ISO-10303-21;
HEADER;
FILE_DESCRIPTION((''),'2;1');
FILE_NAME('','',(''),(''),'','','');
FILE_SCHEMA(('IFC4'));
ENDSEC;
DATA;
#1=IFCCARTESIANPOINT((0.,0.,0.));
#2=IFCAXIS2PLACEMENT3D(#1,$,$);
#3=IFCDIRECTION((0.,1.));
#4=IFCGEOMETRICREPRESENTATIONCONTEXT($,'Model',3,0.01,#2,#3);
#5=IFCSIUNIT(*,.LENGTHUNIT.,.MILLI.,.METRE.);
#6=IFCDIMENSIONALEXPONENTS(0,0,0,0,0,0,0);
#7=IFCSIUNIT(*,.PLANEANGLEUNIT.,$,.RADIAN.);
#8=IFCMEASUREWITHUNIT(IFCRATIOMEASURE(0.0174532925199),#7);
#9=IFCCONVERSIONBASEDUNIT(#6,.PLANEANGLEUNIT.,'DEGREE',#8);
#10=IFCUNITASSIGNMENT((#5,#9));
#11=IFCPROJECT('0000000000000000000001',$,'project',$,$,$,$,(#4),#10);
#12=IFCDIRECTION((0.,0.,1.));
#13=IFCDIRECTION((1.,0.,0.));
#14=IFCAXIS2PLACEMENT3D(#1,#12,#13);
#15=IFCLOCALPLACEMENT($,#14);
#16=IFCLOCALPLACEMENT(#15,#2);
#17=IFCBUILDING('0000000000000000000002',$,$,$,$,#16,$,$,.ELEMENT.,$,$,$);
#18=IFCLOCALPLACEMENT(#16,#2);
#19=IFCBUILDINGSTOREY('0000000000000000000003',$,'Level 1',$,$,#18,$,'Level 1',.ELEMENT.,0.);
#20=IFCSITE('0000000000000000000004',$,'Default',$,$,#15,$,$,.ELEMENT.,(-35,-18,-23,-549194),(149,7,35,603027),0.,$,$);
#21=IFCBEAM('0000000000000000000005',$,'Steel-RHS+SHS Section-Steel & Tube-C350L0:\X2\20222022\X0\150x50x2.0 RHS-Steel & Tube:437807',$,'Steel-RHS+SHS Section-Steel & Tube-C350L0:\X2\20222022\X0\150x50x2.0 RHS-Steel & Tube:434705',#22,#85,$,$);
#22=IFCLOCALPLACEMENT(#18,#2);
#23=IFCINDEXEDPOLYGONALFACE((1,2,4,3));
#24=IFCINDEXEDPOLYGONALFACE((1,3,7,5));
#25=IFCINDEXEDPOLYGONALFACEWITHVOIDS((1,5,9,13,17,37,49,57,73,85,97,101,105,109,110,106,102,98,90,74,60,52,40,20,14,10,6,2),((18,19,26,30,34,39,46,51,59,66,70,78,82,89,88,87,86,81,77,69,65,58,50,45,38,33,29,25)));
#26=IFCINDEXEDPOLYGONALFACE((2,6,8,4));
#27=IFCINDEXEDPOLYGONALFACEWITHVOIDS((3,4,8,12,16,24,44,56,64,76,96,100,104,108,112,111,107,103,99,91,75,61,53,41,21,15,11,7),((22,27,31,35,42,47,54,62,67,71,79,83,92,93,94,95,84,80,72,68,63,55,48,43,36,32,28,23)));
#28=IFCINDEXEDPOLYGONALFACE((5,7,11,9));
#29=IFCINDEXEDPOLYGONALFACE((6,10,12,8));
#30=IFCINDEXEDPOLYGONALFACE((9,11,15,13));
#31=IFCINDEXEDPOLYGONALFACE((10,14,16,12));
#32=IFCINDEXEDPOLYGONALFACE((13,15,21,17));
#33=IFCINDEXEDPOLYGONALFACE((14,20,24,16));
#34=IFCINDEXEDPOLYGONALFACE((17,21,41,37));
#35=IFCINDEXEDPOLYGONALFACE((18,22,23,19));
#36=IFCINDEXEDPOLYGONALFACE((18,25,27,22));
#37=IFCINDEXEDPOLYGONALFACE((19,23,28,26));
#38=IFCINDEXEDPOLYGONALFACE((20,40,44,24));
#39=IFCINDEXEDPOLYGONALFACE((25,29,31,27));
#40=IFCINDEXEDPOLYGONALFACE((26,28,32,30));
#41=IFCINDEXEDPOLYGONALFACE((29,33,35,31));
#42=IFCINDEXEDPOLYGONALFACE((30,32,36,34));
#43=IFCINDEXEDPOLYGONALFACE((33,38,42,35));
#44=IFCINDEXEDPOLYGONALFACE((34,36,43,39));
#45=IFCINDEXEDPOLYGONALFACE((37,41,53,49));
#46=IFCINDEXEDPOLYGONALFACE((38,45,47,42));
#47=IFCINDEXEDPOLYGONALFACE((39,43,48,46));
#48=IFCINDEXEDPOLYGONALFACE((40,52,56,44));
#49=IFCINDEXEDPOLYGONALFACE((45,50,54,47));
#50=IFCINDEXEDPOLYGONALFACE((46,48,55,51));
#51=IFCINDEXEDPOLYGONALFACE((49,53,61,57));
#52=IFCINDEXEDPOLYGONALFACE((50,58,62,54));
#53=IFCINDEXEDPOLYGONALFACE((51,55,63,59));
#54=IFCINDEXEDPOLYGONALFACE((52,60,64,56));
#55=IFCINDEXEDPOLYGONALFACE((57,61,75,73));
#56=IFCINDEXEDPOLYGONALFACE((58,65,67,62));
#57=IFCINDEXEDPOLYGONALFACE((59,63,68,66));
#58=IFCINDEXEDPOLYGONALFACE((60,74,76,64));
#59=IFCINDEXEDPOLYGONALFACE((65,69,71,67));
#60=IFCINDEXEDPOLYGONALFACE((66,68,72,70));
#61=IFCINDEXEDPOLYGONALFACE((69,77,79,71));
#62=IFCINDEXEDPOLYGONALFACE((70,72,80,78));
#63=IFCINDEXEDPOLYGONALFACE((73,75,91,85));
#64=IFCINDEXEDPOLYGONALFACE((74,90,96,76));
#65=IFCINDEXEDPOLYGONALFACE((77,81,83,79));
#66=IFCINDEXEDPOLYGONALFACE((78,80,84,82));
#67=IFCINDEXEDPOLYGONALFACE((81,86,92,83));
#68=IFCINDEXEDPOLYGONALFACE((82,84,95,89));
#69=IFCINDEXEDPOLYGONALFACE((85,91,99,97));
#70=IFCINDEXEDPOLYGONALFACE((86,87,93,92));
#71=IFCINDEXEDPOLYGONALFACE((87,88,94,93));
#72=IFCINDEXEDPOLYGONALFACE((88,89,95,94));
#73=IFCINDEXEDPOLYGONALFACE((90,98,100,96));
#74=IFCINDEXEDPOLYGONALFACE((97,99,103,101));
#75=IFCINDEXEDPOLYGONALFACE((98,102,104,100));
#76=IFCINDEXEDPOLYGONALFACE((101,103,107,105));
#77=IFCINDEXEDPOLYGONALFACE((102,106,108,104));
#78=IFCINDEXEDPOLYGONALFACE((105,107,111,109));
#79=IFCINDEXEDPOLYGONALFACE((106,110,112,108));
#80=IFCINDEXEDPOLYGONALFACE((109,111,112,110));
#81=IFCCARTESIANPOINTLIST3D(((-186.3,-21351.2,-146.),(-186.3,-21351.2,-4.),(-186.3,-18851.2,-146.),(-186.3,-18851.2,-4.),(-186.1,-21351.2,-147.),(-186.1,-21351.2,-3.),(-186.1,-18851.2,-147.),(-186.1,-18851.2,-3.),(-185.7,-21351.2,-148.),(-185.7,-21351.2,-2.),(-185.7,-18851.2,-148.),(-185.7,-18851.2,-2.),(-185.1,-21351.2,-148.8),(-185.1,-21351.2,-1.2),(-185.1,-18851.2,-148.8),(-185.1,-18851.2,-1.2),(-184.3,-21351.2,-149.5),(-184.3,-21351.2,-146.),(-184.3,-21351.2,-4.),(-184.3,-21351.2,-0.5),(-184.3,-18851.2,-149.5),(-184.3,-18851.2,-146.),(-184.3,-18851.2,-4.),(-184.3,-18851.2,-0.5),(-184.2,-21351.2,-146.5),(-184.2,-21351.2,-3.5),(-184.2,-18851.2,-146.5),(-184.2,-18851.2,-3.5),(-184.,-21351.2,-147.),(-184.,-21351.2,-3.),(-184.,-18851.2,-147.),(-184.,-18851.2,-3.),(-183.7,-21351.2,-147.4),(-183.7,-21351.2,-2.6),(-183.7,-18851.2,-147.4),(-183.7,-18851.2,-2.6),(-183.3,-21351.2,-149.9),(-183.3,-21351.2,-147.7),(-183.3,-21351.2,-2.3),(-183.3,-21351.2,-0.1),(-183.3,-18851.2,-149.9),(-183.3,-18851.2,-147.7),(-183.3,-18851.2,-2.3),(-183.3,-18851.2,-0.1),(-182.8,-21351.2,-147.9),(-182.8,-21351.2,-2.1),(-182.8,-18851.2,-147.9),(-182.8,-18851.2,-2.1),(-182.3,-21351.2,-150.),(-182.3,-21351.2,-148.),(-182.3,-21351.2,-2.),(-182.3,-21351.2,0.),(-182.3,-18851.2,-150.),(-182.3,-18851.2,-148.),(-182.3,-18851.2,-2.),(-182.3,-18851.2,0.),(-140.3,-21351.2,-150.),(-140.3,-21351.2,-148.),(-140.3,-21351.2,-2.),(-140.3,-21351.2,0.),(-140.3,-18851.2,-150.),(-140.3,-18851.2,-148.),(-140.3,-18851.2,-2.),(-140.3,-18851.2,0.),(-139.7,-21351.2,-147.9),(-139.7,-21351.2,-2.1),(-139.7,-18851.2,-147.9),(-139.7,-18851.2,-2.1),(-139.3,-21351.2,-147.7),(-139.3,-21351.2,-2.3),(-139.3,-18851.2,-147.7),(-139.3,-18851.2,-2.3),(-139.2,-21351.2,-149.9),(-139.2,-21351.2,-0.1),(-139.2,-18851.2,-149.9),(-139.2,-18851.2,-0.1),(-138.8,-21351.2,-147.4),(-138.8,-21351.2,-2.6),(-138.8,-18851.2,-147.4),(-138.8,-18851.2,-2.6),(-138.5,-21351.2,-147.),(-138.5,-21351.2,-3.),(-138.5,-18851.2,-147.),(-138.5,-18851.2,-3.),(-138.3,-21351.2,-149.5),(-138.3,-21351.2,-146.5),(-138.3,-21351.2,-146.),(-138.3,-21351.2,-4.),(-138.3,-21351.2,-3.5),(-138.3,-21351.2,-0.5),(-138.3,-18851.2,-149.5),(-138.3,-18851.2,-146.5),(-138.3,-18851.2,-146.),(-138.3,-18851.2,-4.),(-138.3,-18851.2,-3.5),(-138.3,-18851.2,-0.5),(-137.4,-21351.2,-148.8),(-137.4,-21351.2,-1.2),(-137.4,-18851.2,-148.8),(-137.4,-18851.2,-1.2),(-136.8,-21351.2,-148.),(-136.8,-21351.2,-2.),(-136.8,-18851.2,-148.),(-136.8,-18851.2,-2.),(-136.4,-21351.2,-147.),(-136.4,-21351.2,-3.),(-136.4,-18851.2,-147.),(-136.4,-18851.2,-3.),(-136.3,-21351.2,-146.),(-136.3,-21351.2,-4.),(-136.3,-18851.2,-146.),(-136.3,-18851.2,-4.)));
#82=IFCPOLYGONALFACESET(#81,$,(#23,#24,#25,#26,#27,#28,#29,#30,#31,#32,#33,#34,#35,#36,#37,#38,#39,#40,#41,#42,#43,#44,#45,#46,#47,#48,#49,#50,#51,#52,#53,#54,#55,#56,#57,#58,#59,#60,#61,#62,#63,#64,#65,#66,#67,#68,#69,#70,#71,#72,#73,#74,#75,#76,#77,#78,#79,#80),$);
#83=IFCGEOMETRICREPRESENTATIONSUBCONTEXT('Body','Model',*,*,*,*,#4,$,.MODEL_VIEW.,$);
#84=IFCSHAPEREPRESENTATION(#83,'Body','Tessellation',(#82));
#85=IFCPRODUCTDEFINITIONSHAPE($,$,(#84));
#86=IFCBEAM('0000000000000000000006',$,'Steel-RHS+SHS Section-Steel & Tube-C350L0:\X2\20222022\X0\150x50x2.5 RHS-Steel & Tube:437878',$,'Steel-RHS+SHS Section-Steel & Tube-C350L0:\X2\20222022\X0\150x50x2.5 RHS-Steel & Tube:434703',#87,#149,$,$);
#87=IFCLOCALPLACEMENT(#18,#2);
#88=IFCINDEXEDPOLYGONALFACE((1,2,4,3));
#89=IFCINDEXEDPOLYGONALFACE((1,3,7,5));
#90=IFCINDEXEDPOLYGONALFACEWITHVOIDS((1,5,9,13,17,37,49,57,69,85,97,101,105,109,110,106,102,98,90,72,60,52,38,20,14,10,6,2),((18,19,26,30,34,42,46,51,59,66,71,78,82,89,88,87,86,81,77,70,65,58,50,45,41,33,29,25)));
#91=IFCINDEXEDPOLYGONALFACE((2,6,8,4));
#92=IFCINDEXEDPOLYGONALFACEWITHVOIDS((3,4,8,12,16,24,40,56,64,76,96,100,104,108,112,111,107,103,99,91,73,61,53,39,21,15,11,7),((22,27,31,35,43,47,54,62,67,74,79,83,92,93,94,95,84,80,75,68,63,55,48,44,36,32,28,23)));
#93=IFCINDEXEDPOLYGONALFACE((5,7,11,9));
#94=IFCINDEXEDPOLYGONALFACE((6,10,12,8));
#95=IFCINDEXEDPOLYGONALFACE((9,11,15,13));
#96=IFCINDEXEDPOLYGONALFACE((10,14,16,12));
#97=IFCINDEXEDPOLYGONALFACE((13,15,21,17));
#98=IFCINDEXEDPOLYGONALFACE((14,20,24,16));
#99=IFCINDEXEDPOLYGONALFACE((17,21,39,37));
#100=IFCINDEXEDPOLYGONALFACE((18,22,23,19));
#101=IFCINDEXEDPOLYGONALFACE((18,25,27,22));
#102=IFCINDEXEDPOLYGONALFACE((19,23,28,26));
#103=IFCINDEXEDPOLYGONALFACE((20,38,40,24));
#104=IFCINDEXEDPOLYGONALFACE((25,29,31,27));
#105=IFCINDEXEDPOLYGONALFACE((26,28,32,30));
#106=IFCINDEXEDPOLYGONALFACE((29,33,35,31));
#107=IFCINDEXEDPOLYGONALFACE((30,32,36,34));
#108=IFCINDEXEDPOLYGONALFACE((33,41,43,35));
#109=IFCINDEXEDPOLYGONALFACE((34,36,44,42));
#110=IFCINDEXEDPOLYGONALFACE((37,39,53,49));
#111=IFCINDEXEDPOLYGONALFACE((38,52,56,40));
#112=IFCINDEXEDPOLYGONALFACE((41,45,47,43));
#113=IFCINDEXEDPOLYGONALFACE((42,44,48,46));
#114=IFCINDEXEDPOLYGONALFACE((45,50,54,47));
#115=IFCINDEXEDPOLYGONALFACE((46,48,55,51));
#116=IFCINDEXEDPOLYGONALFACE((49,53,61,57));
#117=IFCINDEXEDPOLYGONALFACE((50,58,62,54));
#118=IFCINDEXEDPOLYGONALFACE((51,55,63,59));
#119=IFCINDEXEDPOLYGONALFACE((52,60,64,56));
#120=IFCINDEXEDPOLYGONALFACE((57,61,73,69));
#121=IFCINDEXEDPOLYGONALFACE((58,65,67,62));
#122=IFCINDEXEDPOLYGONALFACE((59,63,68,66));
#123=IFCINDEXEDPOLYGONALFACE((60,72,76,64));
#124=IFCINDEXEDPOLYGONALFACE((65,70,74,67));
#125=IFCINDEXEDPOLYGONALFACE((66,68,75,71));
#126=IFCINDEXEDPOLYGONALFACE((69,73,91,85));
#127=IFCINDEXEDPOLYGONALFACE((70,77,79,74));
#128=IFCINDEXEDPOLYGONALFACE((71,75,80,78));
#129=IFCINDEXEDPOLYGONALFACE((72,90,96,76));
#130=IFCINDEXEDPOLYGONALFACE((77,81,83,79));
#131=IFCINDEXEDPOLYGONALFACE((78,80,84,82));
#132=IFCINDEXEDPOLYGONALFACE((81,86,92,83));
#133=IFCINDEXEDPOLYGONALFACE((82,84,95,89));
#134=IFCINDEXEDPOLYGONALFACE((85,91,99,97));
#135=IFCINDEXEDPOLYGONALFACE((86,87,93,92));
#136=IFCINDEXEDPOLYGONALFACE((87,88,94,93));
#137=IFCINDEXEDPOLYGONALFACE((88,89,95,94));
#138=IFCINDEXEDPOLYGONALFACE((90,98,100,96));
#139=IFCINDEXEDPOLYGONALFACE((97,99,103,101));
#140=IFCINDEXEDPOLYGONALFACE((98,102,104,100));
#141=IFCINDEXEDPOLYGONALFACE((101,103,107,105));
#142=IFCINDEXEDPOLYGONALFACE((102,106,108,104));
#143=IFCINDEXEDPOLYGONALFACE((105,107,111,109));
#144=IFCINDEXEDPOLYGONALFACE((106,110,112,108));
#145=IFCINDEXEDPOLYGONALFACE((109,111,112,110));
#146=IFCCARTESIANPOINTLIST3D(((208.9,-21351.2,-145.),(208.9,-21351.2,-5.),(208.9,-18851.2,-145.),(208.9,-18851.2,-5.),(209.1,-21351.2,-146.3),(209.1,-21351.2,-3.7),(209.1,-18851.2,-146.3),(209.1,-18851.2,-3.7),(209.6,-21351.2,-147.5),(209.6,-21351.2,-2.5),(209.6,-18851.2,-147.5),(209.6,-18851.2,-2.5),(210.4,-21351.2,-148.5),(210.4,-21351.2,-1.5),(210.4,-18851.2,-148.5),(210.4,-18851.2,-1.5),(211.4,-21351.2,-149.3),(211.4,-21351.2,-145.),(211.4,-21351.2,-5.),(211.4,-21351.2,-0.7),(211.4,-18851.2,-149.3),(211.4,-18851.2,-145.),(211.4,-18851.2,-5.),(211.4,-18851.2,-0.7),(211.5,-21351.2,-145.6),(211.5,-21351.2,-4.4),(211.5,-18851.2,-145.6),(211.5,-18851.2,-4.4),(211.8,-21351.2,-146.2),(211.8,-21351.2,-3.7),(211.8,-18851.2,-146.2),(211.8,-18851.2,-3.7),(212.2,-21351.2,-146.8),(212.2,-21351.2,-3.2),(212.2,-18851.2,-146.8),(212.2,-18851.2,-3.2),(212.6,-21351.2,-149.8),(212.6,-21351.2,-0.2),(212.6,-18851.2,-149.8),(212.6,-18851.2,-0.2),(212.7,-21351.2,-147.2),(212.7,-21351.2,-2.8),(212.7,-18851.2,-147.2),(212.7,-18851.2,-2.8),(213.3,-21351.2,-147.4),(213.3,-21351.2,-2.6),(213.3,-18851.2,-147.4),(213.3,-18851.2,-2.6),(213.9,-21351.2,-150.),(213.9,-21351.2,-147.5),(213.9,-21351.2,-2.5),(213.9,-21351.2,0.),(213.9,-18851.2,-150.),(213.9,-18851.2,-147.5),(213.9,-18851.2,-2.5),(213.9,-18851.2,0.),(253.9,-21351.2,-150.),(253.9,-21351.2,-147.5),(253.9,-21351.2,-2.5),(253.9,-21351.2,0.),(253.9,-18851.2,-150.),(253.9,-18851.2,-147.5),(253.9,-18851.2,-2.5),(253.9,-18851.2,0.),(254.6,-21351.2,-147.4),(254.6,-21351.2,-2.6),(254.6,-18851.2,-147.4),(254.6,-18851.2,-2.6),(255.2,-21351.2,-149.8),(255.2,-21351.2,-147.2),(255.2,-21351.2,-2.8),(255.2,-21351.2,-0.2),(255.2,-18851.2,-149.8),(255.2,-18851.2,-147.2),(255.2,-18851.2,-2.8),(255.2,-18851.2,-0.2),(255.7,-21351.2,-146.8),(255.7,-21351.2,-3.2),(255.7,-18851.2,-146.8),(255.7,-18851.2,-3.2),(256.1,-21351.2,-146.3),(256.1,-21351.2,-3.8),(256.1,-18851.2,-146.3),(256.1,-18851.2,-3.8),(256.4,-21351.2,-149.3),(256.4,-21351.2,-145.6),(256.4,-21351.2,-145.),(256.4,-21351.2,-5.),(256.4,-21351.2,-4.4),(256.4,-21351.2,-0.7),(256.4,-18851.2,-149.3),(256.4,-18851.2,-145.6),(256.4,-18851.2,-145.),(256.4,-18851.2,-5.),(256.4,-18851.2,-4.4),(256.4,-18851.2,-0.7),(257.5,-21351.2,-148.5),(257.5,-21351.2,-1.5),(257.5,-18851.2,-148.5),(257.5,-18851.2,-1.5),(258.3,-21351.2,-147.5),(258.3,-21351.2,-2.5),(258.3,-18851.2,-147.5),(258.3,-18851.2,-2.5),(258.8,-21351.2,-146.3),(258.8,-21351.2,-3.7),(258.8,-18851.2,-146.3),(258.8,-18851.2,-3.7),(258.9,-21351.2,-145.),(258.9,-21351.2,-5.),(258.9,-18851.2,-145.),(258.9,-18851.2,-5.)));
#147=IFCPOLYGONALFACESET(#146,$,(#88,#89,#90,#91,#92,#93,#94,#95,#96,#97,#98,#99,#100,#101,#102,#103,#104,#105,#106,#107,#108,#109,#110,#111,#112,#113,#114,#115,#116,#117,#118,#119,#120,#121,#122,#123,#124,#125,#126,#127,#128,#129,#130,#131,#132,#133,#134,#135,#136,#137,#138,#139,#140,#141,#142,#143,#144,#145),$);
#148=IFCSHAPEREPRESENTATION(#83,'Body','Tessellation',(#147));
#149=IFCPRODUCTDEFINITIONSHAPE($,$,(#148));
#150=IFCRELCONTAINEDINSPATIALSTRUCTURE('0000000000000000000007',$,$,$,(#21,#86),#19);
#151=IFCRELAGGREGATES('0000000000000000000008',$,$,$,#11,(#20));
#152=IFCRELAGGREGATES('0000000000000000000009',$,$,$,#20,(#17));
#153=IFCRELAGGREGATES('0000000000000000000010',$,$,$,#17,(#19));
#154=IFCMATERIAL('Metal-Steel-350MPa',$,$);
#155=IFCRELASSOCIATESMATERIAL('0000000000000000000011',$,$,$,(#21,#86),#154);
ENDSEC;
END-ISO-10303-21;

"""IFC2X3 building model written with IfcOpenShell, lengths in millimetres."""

from ifc_helpers import new_model, entity, si_unit, converted_unit, direction, frame, frame_2d, origin, origin_with_axes, place, context, subcontext, project, spatial, polyline, circle_curve, parameter, trimmed, segment, composite_curve, outline, extrude, material, element, save


model = new_model("IFC2X3")

# Units and contexts
model_context = context("Model", 3, precision=0.01, world=origin(), true_north=direction((0.0, 1.0)))
body_context = subcontext(model_context, "Body", "Model", "MODEL_VIEW")
ifc_project = project(units=[si_unit("LENGTHUNIT", "METRE", prefix="MILLI"), converted_unit("PLANEANGLEUNIT", "DEGREE", entity("IfcRatioMeasure", 0.0174532925199), si_unit("PLANEANGLEUNIT", "RADIAN"), dimensions=[0, 0, 0, 0, 0, 0, 0])], contexts=[model_context])

# Site, building, storey
site_placement = place(None, origin_with_axes())
site = spatial("IfcSite", under=ifc_project, at=site_placement, Name="Default", CompositionType="ELEMENT", RefLatitude=(-35, -18, -23, -549194), RefLongitude=(149, 7, 35, 603027), RefElevation=0.0)
building_placement = place(site_placement, origin())
building = spatial("IfcBuilding", under=site, at=building_placement, CompositionType="ELEMENT")
storey_placement = place(building_placement, origin())
storey = spatial("IfcBuildingStorey", under=building, at=storey_placement, Name="Level 1", LongName="Level 1", CompositionType="ELEMENT", Elevation=0.0)

# Beams
ifc_material = material(Name="Metal-Steel-350MPa")
beam_1_placement = place(storey_placement, frame((-161.3, -18851.2, 0.0), z_axis=(0.0, 0.0, 1.0), x_axis=(0.0, -1.0, 0.0)))
element("IfcBeam", 1, at=beam_1_placement, inside=storey, material=ifc_material, Name="Steel-RHS+SHS Section-Steel & Tube-C350L0:••150x50x2.0 RHS-Steel & Tube:437807", ObjectType="Steel-RHS+SHS Section-Steel & Tube-C350L0:••150x50x2.0 RHS-Steel & Tube:434705", context=body_context, shape_type="SweptSolid", body=[
    extrude(outline(composite_curve([segment(trimmed(circle_curve(frame_2d((-21.0, -71.0), x_axis=(1.0, 0.0)), 4.0), [parameter(180.0)], [parameter(270.0)], True, "PARAMETER"), True, "CONTINUOUS"), segment(polyline([(-21.0, -75.0), (21.0, -75.0)]), True, "CONTINUOUS"), segment(trimmed(circle_curve(frame_2d((21.0, -71.0), x_axis=(1.0, 0.0)), 4.0), [parameter(270.0)], [parameter(0.0)], True, "PARAMETER"), True, "CONTINUOUS"), segment(polyline([(25.0, -71.0), (25.0, 71.0)]), True, "CONTINUOUS"), segment(trimmed(circle_curve(frame_2d((21.0, 71.0), x_axis=(1.0, 0.0)), 4.0), [parameter(0.0)], [parameter(90.0)], True, "PARAMETER"), True, "CONTINUOUS"), segment(polyline([(21.0, 75.0), (-21.0, 75.0)]), True, "CONTINUOUS"), segment(trimmed(circle_curve(frame_2d((-21.0, 71.0), x_axis=(1.0, 0.0)), 4.0), [parameter(90.0)], [parameter(180.0)], True, "PARAMETER"), True, "CONTINUOUS"), segment(polyline([(-25.0, 71.0), (-25.0, -71.0)]), True, "CONTINUOUS")], self_intersect=False), holes=[composite_curve([segment(polyline([(21.0, -73.0), (-21.0, -73.0)]), True, "CONTINUOUS"), segment(trimmed(circle_curve(frame_2d((-21.0, -71.0), x_axis=(1.0, 0.0)), 2.0), [parameter(180.0)], [parameter(270.0)], True, "PARAMETER"), False, "CONTINUOUS"), segment(polyline([(-23.0, -71.0), (-23.0, 71.0)]), True, "CONTINUOUS"), segment(trimmed(circle_curve(frame_2d((-21.0, 71.0), x_axis=(1.0, 0.0)), 2.0), [parameter(90.0)], [parameter(180.0)], True, "PARAMETER"), False, "CONTINUOUS"), segment(polyline([(-21.0, 73.0), (21.0, 73.0)]), True, "CONTINUOUS"), segment(trimmed(circle_curve(frame_2d((21.0, 71.0), x_axis=(1.0, 0.0)), 2.0), [parameter(360.0)], [parameter(90.0)], True, "PARAMETER"), False, "CONTINUOUS"), segment(polyline([(23.0, 71.0), (23.0, -71.0)]), True, "CONTINUOUS"), segment(trimmed(circle_curve(frame_2d((21.0, -71.0), x_axis=(1.0, 0.0)), 2.0), [parameter(270.0)], [parameter(0.0)], True, "PARAMETER"), False, "CONTINUOUS")], self_intersect=False)]), frame((0.0, 0.0, -75.0), z_axis=(1.0, 0.0, 0.0), x_axis=(0.0, -1.0, 0.0)), (0.0, 0.0, 1.0), 2500.0),
])
beam_2_placement = place(storey_placement, frame((233.9, -18851.2, 0.0), z_axis=(0.0, 0.0, 1.0), x_axis=(0.0, -1.0, 0.0)))
element("IfcBeam", 2, at=beam_2_placement, inside=storey, material=ifc_material, Name="Steel-RHS+SHS Section-Steel & Tube-C350L0:••150x50x2.5 RHS-Steel & Tube:437878", ObjectType="Steel-RHS+SHS Section-Steel & Tube-C350L0:••150x50x2.5 RHS-Steel & Tube:434703", context=body_context, shape_type="SweptSolid", body=[
    extrude(outline(composite_curve([segment(trimmed(circle_curve(frame_2d((-20.0, -70.0), x_axis=(1.0, 0.0)), 5.0), [parameter(180.0)], [parameter(270.0)], True, "PARAMETER"), True, "CONTINUOUS"), segment(polyline([(-20.0, -75.0), (20.0, -75.0)]), True, "CONTINUOUS"), segment(trimmed(circle_curve(frame_2d((20.0, -70.0), x_axis=(1.0, 0.0)), 5.0), [parameter(270.0)], [parameter(0.0)], True, "PARAMETER"), True, "CONTINUOUS"), segment(polyline([(25.0, -70.0), (25.0, 70.0)]), True, "CONTINUOUS"), segment(trimmed(circle_curve(frame_2d((20.0, 70.0), x_axis=(1.0, 0.0)), 5.0), [parameter(0.0)], [parameter(90.0)], True, "PARAMETER"), True, "CONTINUOUS"), segment(polyline([(20.0, 75.0), (-20.0, 75.0)]), True, "CONTINUOUS"), segment(trimmed(circle_curve(frame_2d((-20.0, 70.0), x_axis=(1.0, 0.0)), 5.0), [parameter(90.0)], [parameter(180.0)], True, "PARAMETER"), True, "CONTINUOUS"), segment(polyline([(-25.0, 70.0), (-25.0, -70.0)]), True, "CONTINUOUS")], self_intersect=False), holes=[composite_curve([segment(polyline([(20.0, -72.5), (-20.0, -72.5)]), True, "CONTINUOUS"), segment(trimmed(circle_curve(frame_2d((-20.0, -70.0), x_axis=(1.0, 0.0)), 2.5), [parameter(180.0)], [parameter(270.0)], True, "PARAMETER"), False, "CONTINUOUS"), segment(polyline([(-22.5, -70.0), (-22.5, 70.0)]), True, "CONTINUOUS"), segment(trimmed(circle_curve(frame_2d((-20.0, 70.0), x_axis=(1.0, 0.0)), 2.5), [parameter(90.0)], [parameter(180.0)], True, "PARAMETER"), False, "CONTINUOUS"), segment(polyline([(-20.0, 72.5), (20.0, 72.5)]), True, "CONTINUOUS"), segment(trimmed(circle_curve(frame_2d((20.0, 70.0), x_axis=(1.0, 0.0)), 2.5), [parameter(360.0)], [parameter(90.0)], True, "PARAMETER"), False, "CONTINUOUS"), segment(polyline([(22.5, 70.0), (22.5, -70.0)]), True, "CONTINUOUS"), segment(trimmed(circle_curve(frame_2d((20.0, -70.0), x_axis=(1.0, 0.0)), 2.5), [parameter(270.0)], [parameter(0.0)], True, "PARAMETER"), False, "CONTINUOUS")], self_intersect=False)]), frame((0.0, 0.0, -75.0), z_axis=(1.0, 0.0, 0.0), x_axis=(0.0, -1.0, 0.0)), (0.0, 0.0, 1.0), 2500.0),
])

save(model, "model.ifc")
